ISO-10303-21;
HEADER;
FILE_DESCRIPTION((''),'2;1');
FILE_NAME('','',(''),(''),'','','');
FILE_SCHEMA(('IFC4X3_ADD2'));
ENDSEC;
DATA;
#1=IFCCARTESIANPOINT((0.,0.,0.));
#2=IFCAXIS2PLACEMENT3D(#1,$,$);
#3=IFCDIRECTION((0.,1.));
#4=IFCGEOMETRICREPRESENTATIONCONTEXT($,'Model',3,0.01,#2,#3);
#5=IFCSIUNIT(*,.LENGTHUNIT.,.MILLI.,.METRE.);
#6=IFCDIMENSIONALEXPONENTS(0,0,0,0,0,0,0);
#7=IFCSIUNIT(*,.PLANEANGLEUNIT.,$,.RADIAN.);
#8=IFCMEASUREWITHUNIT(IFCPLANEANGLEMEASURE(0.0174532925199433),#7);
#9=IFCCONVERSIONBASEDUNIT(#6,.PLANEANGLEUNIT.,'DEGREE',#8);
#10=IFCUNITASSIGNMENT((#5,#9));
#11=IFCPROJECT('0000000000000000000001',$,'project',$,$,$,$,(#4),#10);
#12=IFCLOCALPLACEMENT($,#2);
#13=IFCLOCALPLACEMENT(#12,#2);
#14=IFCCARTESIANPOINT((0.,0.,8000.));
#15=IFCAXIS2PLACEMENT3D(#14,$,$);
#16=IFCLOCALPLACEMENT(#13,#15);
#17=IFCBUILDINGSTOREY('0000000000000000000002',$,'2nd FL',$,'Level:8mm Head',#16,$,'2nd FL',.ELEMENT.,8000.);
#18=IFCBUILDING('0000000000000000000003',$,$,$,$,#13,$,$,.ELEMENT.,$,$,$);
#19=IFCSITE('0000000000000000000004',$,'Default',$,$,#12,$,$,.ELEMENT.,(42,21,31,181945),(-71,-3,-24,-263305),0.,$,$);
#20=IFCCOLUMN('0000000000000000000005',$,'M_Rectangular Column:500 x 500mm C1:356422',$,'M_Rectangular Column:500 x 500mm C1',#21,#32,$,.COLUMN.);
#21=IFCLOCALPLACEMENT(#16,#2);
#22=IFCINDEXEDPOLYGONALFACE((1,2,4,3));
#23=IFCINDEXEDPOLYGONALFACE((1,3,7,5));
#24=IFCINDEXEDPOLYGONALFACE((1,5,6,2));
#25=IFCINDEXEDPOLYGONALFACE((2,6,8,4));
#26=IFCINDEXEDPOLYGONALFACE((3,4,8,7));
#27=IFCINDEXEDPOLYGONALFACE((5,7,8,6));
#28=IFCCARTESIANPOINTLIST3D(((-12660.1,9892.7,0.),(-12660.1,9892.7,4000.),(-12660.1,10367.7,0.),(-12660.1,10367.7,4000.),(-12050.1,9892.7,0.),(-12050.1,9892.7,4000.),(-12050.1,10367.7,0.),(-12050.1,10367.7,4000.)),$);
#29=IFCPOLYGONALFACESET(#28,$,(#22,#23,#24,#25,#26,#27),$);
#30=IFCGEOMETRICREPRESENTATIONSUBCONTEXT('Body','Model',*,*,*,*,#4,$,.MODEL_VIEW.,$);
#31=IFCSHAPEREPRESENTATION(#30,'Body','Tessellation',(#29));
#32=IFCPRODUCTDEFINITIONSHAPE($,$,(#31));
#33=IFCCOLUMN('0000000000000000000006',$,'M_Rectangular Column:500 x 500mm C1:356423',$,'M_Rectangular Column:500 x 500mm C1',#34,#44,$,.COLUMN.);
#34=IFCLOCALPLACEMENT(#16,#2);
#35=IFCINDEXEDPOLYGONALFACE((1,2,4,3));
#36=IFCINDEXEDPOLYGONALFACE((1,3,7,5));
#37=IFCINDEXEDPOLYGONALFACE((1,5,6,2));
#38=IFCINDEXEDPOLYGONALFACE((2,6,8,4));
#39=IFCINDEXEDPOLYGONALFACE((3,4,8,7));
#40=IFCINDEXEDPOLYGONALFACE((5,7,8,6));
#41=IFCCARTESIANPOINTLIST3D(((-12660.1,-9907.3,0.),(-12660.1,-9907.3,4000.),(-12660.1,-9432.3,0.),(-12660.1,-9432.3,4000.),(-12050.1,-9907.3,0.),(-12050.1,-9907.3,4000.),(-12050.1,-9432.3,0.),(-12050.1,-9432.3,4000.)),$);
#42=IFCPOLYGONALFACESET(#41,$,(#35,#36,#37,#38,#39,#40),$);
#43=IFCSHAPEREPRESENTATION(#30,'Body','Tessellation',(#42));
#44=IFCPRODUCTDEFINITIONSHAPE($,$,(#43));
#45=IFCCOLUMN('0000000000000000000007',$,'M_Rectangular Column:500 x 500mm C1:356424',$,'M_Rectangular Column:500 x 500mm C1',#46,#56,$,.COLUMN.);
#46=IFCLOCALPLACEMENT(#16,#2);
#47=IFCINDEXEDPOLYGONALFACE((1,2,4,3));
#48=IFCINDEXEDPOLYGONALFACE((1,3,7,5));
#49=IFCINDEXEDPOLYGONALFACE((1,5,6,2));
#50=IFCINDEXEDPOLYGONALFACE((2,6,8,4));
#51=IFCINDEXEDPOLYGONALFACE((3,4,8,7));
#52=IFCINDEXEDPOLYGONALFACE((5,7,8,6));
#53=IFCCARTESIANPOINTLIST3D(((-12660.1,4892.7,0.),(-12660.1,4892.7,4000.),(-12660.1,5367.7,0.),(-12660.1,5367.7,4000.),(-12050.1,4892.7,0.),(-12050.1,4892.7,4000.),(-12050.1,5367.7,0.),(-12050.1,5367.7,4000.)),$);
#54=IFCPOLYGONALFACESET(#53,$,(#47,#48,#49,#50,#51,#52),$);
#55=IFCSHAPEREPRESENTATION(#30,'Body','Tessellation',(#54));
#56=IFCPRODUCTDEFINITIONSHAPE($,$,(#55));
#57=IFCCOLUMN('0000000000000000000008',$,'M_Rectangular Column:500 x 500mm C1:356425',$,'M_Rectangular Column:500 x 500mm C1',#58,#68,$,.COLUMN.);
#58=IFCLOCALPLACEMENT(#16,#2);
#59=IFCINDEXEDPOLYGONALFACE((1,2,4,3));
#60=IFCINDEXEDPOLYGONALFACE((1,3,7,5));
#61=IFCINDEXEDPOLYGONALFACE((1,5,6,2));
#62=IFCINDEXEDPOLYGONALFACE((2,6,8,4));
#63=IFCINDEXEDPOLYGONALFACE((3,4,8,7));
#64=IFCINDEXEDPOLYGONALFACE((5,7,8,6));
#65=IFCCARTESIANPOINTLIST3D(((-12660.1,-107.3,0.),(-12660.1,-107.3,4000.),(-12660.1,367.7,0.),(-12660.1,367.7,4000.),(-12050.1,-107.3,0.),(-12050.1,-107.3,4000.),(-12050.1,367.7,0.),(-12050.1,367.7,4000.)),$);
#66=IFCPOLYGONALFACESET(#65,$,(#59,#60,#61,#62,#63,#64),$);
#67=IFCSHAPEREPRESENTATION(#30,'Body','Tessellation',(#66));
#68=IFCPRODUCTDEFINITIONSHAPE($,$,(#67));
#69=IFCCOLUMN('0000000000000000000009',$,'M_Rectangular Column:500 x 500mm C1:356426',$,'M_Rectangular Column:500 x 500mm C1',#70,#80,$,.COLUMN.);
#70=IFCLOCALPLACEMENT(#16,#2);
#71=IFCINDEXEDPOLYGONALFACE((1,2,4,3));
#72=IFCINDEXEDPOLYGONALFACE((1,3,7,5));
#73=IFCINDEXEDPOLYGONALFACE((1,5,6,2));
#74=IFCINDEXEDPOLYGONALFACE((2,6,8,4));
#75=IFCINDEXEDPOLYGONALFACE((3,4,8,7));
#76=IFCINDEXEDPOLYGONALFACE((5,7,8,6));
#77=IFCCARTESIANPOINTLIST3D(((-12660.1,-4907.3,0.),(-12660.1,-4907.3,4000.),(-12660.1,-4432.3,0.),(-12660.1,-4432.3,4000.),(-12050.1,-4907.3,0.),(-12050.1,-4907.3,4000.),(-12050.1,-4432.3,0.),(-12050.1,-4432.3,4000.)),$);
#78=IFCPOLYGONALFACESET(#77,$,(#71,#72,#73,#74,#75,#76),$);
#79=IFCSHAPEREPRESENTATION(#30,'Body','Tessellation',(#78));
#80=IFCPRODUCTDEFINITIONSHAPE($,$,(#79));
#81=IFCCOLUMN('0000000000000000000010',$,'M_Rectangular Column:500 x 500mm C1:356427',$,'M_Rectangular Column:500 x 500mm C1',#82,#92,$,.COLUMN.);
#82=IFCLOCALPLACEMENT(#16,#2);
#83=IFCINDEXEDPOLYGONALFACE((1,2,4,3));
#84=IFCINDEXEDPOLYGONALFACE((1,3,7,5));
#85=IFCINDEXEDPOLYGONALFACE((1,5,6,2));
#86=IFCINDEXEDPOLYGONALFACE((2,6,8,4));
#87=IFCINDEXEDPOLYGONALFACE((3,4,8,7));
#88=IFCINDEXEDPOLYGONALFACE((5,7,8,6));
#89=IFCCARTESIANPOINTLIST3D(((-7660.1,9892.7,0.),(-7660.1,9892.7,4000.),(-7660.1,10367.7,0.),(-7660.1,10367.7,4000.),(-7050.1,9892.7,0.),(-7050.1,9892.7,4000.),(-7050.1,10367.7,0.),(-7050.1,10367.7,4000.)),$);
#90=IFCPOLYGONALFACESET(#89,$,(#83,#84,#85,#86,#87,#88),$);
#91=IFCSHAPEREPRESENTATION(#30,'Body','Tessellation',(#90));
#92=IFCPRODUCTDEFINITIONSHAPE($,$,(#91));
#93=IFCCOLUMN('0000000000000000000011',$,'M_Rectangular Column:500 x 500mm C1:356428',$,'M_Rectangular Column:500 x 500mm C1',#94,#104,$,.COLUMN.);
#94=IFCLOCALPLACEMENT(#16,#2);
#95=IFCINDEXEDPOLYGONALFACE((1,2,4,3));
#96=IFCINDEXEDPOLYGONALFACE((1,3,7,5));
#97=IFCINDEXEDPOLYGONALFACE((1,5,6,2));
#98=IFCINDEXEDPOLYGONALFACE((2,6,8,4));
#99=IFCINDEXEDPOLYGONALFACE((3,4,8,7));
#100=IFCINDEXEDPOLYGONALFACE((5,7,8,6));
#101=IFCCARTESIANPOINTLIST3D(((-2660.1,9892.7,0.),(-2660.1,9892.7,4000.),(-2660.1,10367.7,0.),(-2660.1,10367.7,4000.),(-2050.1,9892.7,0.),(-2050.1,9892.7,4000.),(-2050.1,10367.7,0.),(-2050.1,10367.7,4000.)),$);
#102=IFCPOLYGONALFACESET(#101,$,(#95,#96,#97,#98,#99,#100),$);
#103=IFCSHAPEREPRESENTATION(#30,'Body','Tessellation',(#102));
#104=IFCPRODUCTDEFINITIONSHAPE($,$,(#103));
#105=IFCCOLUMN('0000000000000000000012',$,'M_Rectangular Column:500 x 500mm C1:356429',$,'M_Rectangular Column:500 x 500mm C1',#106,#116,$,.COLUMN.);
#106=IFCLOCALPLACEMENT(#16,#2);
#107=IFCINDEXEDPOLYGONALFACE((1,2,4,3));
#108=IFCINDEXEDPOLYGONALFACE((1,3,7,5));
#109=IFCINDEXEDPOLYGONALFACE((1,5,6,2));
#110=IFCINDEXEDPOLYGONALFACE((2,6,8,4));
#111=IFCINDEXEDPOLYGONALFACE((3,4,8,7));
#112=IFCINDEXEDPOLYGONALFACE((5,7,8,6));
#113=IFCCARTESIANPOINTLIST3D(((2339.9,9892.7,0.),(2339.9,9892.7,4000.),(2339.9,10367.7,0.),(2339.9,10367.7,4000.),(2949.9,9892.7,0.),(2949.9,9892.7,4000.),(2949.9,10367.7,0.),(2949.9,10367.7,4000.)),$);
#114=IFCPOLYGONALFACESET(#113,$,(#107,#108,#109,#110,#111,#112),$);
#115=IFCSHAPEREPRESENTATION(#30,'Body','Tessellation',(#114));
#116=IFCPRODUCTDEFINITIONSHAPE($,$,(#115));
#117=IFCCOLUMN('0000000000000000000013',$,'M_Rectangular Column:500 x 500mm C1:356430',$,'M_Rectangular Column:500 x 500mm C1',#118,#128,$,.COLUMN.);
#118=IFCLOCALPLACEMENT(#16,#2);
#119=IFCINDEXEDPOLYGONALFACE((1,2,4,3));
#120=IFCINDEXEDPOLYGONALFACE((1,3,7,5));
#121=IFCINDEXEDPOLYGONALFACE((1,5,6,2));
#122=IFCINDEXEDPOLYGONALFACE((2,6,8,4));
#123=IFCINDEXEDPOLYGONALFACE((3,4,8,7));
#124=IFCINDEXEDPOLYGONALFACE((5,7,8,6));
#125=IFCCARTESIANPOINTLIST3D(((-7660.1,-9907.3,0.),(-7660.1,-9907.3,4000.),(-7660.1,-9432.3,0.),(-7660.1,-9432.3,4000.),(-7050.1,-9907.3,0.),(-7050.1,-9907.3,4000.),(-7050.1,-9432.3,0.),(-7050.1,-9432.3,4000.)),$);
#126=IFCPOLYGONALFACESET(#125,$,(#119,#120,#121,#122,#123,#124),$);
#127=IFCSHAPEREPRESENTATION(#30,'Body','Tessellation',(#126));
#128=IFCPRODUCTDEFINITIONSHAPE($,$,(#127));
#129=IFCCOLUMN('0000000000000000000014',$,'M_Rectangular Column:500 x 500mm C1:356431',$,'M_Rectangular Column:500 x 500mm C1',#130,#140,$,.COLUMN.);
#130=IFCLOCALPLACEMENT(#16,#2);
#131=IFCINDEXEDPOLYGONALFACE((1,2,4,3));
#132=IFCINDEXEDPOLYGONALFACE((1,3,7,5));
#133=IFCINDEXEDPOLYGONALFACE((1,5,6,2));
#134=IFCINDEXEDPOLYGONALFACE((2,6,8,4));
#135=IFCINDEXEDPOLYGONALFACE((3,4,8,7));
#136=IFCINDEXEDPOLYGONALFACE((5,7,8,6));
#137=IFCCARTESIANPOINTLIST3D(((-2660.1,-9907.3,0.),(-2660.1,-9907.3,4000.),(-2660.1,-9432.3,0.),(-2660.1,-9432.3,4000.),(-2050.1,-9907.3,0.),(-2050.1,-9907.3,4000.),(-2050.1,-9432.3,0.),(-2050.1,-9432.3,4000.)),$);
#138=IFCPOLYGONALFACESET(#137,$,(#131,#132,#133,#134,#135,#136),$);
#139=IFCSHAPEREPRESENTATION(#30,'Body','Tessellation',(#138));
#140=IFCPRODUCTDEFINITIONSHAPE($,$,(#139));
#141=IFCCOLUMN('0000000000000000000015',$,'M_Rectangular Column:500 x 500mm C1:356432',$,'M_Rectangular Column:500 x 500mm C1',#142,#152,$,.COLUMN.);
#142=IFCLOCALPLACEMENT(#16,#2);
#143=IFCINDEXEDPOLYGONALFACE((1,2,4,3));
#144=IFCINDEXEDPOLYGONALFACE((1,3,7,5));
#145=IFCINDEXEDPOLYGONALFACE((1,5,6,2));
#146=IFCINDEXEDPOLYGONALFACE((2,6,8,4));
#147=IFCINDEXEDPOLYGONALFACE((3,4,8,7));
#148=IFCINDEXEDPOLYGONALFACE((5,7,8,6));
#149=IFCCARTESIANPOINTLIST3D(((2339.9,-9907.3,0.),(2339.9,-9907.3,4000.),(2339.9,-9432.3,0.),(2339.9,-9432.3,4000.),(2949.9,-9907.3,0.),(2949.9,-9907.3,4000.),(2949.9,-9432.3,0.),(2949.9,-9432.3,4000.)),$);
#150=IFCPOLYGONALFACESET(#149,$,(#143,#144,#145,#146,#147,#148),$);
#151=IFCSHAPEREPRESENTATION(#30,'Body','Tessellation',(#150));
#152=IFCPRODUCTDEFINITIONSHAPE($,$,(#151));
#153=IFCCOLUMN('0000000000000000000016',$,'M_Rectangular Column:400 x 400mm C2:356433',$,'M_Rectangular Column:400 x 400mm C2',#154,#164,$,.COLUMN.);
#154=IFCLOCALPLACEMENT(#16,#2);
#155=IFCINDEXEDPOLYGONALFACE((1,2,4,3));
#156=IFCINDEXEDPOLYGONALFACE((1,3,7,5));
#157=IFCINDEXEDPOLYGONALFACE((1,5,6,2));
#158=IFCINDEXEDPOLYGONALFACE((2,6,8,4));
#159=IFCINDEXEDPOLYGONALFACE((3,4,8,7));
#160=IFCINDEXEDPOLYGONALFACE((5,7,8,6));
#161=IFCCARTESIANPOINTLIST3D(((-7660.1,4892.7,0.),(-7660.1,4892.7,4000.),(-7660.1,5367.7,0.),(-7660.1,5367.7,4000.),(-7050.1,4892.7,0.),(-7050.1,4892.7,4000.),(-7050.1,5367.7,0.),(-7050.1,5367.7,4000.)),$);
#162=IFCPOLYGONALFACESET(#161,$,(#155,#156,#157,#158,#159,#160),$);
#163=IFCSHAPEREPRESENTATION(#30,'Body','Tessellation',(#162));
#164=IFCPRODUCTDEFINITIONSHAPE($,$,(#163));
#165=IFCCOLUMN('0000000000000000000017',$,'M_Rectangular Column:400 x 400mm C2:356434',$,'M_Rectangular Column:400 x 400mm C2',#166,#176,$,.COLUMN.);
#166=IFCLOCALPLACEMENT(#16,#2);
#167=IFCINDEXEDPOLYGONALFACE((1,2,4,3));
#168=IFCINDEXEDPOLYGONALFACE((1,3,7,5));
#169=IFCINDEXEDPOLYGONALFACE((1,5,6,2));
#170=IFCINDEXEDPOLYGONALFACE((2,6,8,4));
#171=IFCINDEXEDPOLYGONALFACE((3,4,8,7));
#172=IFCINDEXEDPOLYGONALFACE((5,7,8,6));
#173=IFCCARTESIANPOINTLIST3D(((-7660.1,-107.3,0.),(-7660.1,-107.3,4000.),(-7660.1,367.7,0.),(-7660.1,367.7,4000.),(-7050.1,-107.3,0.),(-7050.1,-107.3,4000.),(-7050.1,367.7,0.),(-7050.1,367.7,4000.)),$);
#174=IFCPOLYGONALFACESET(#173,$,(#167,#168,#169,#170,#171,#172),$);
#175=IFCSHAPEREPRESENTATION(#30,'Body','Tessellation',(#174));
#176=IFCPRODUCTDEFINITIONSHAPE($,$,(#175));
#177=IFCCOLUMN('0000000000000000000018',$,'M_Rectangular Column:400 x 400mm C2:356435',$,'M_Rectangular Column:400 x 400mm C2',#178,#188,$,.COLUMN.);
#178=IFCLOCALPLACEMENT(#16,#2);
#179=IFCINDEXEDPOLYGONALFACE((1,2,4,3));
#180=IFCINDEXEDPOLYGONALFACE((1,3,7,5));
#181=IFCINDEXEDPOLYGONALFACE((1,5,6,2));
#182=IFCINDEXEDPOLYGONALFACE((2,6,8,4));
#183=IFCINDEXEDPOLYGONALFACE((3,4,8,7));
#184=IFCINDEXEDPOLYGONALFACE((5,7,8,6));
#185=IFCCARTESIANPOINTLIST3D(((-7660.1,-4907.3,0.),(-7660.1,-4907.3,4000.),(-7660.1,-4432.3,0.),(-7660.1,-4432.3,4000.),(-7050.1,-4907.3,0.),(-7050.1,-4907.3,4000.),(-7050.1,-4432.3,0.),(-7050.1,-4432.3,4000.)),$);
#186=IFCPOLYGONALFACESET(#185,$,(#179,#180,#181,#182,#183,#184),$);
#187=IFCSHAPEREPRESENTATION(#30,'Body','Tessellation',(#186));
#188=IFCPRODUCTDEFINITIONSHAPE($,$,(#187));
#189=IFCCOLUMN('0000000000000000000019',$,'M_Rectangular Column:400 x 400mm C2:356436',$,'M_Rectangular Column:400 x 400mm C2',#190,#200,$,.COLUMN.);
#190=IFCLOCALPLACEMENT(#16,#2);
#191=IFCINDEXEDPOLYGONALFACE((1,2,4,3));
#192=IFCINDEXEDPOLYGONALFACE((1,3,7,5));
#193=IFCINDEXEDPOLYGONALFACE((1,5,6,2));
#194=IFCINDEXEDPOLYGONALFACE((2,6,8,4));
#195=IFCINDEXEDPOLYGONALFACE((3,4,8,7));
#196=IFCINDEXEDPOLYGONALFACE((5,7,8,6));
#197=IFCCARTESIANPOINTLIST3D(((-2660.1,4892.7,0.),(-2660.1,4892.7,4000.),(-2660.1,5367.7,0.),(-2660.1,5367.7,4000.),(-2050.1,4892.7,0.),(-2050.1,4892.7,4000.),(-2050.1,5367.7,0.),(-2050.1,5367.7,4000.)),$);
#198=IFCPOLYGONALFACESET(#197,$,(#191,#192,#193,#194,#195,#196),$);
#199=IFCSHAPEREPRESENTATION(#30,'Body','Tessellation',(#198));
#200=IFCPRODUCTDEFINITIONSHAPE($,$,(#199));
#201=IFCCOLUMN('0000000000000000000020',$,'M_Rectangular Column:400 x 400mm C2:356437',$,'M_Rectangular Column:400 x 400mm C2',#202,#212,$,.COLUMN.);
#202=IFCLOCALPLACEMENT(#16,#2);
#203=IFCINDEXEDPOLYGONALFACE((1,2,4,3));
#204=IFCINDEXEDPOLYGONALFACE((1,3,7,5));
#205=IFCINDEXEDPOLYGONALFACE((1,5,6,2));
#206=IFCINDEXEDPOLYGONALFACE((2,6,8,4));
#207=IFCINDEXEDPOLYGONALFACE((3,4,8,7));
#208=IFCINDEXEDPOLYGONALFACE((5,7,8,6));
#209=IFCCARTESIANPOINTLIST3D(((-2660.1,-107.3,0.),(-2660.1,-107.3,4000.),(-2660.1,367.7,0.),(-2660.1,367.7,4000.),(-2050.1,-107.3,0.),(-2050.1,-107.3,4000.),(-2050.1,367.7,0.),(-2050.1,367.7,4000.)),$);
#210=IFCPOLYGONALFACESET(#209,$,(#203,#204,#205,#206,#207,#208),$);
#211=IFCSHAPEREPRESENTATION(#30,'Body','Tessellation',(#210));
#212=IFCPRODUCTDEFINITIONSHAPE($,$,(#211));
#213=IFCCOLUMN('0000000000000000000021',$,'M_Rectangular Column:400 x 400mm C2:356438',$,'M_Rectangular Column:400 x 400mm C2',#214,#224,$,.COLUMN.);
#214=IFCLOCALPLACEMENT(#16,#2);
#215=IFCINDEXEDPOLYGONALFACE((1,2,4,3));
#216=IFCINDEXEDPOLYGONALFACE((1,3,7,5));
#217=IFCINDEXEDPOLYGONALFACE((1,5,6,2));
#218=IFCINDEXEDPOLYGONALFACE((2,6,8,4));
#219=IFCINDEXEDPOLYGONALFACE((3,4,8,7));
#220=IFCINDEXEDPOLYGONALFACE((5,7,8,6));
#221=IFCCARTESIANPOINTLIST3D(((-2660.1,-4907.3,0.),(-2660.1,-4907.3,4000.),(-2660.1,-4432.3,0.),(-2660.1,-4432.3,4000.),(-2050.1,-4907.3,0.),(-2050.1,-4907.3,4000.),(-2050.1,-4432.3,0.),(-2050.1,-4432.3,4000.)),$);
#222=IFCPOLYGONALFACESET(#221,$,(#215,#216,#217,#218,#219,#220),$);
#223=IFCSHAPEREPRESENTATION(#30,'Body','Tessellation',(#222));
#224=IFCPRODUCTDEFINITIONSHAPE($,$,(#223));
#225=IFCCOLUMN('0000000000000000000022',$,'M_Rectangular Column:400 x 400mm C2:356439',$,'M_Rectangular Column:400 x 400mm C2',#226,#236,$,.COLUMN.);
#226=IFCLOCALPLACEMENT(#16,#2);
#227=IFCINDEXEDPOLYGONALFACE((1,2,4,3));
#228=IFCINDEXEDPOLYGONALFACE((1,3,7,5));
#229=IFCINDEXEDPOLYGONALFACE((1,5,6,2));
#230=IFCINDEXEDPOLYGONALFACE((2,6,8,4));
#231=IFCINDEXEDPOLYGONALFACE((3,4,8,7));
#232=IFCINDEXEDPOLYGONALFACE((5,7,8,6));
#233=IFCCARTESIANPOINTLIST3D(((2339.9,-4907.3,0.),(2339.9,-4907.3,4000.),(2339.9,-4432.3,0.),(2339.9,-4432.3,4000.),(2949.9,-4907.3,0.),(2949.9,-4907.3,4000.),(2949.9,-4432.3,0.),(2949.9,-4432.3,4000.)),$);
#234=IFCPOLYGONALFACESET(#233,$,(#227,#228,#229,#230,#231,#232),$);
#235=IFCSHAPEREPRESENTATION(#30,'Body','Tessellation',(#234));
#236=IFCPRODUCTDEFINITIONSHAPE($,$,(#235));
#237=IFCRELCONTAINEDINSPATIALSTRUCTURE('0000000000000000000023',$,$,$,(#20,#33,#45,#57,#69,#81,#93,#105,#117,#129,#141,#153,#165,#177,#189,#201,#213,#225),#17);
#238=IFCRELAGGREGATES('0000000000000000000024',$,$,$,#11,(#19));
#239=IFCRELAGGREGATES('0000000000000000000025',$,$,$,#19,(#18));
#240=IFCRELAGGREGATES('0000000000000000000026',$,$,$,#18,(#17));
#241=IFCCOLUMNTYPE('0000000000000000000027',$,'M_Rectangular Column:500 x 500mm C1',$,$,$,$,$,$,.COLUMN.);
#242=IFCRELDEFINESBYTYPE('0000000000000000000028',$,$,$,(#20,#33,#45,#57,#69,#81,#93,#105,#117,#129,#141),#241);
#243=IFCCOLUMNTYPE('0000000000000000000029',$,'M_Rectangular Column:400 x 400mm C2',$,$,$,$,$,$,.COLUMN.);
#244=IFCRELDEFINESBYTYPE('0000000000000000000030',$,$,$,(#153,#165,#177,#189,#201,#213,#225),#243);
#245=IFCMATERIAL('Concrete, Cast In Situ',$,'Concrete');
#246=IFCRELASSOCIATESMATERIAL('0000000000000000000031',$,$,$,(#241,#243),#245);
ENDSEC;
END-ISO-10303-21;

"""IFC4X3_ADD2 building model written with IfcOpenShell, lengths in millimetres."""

from ifc_helpers import new_model, entity, si_unit, converted_unit, direction, frame, frame_2d, origin, origin_2d_with_axis, place, context, subcontext, project, spatial, rectangle, extrude, source, transform, mapped, material, material_profile, profile_set, type_object, type_shapes, element, save


model = new_model("IFC4X3_ADD2")

# Units and contexts
model_context = context("Model", 3, precision=0.01, world=origin(), true_north=direction((0.0, 1.0)))
body_context = subcontext(model_context, "Body", "Model", "MODEL_VIEW")
ifc_project = project(units=[si_unit("LENGTHUNIT", "METRE", prefix="MILLI"), converted_unit("PLANEANGLEUNIT", "DEGREE", entity("IfcPlaneAngleMeasure", 0.0174532925199433), si_unit("PLANEANGLEUNIT", "RADIAN"), dimensions=[0, 0, 0, 0, 0, 0, 0])], contexts=[model_context])

# Site, building, storey
site_placement = place(None, origin())
site = spatial("IfcSite", under=ifc_project, at=site_placement, Name="Default", CompositionType="ELEMENT", RefLatitude=(42, 21, 31, 181945), RefLongitude=(-71, -3, -24, -263305), RefElevation=0.0)
building_placement = place(site_placement, origin())
building = spatial("IfcBuilding", under=site, at=building_placement, CompositionType="ELEMENT")
storey_placement = place(building_placement, frame((0.0, 0.0, 8000.0)))
storey = spatial("IfcBuildingStorey", under=building, at=storey_placement, Name="2nd FL", ObjectType="Level:8mm Head", LongName="2nd FL", CompositionType="ELEMENT", Elevation=8000.0)

# Columns
ifc_material_1 = material(Name="Concrete, Cast In Situ", Category="Concrete")
ifc_material_profile_1 = material_profile(ifc_material_1, rectangle(XDim=610.0, YDim=475.0, at=frame_2d((0.0, 0.0), x_axis=(1.0, 0.0))), Name="500 x 500mm C1")
ifc_profile_set_1 = profile_set([ifc_material_profile_1], Name="500 x 500mm C1")
column_type_1 = type_object("IfcColumnType", Name="M_Rectangular Column:500 x 500mm C1", PredefinedType="COLUMN", material=ifc_profile_set_1)
shared_shape_1 = source(origin(), body_context, "Body", "SweptSolid", [
    extrude(rectangle(XDim=610.0, YDim=475.0, at=origin_2d_with_axis()), frame((0.0, 0.0, 8000.0), z_axis=(0.0, 0.0, 1.0), x_axis=(-1.0, 0.0, 0.0)), (0.0, 0.0, 1.0), 4000.0),
])
type_shapes(column_type_1, [shared_shape_1])
for number, where, name in (
    (1, (-12355.1, 10130.2, -8000.0), "M_Rectangular Column:500 x 500mm C1:356422"),
    (2, (-12355.1, -9669.8, -8000.0), "M_Rectangular Column:500 x 500mm C1:356423"),
    (3, (-12355.1, 5130.2, -8000.0), "M_Rectangular Column:500 x 500mm C1:356424"),
    (4, (-12355.1, 130.2, -8000.0), "M_Rectangular Column:500 x 500mm C1:356425"),
    (5, (-12355.1, -4669.8, -8000.0), "M_Rectangular Column:500 x 500mm C1:356426"),
    (6, (-7355.1, 10130.2, -8000.0), "M_Rectangular Column:500 x 500mm C1:356427"),
    (7, (-2355.1, 10130.2, -8000.0), "M_Rectangular Column:500 x 500mm C1:356428"),
    (8, (2644.9, 10130.2, -8000.0), "M_Rectangular Column:500 x 500mm C1:356429"),
    (9, (-7355.1, -9669.8, -8000.0), "M_Rectangular Column:500 x 500mm C1:356430"),
    (10, (-2355.1, -9669.8, -8000.0), "M_Rectangular Column:500 x 500mm C1:356431"),
    (11, (2644.9, -9669.8, -8000.0), "M_Rectangular Column:500 x 500mm C1:356432"),
):
    element("IfcColumn", number, at=place(storey_placement, frame(where)), inside=storey, type_object=column_type_1, Name=name, ObjectType="M_Rectangular Column:500 x 500mm C1", PredefinedType="COLUMN", context=body_context, shape_type="MappedRepresentation", body=[
        mapped(shared_shape_1, transform((0.0, 0.0, 0.0), scale=1.0)),
    ])
ifc_material_profile_2 = material_profile(ifc_material_1, rectangle(XDim=610.0, YDim=475.0, at=origin_2d_with_axis()), Name="400 x 400mm C2")
ifc_profile_set_2 = profile_set([ifc_material_profile_2], Name="400 x 400mm C2")
column_type_2 = type_object("IfcColumnType", Name="M_Rectangular Column:400 x 400mm C2", PredefinedType="COLUMN", material=ifc_profile_set_2)
shared_shape_2 = source(origin(), body_context, "Body", "SweptSolid", [
    extrude(rectangle(XDim=610.0, YDim=475.0, at=origin_2d_with_axis()), frame((0.0, 0.0, 8000.0), z_axis=(0.0, 0.0, 1.0), x_axis=(-1.0, 0.0, 0.0)), (0.0, 0.0, 1.0), 4000.0),
])
type_shapes(column_type_2, [shared_shape_2])
for number, where, name in (
    (12, (-7355.1, 5130.2, -8000.0), "M_Rectangular Column:400 x 400mm C2:356433"),
    (13, (-7355.1, 130.2, -8000.0), "M_Rectangular Column:400 x 400mm C2:356434"),
    (14, (-7355.1, -4669.8, -8000.0), "M_Rectangular Column:400 x 400mm C2:356435"),
    (15, (-2355.1, 5130.2, -8000.0), "M_Rectangular Column:400 x 400mm C2:356436"),
    (16, (-2355.1, 130.2, -8000.0), "M_Rectangular Column:400 x 400mm C2:356437"),
    (17, (-2355.1, -4669.8, -8000.0), "M_Rectangular Column:400 x 400mm C2:356438"),
    (18, (2644.9, -4669.8, -8000.0), "M_Rectangular Column:400 x 400mm C2:356439"),
):
    element("IfcColumn", number, at=place(storey_placement, frame(where)), inside=storey, type_object=column_type_2, Name=name, ObjectType="M_Rectangular Column:400 x 400mm C2", PredefinedType="COLUMN", context=body_context, shape_type="MappedRepresentation", body=[
        mapped(shared_shape_2, transform((0.0, 0.0, 0.0), scale=1.0)),
    ])

save(model, "model.ifc")
